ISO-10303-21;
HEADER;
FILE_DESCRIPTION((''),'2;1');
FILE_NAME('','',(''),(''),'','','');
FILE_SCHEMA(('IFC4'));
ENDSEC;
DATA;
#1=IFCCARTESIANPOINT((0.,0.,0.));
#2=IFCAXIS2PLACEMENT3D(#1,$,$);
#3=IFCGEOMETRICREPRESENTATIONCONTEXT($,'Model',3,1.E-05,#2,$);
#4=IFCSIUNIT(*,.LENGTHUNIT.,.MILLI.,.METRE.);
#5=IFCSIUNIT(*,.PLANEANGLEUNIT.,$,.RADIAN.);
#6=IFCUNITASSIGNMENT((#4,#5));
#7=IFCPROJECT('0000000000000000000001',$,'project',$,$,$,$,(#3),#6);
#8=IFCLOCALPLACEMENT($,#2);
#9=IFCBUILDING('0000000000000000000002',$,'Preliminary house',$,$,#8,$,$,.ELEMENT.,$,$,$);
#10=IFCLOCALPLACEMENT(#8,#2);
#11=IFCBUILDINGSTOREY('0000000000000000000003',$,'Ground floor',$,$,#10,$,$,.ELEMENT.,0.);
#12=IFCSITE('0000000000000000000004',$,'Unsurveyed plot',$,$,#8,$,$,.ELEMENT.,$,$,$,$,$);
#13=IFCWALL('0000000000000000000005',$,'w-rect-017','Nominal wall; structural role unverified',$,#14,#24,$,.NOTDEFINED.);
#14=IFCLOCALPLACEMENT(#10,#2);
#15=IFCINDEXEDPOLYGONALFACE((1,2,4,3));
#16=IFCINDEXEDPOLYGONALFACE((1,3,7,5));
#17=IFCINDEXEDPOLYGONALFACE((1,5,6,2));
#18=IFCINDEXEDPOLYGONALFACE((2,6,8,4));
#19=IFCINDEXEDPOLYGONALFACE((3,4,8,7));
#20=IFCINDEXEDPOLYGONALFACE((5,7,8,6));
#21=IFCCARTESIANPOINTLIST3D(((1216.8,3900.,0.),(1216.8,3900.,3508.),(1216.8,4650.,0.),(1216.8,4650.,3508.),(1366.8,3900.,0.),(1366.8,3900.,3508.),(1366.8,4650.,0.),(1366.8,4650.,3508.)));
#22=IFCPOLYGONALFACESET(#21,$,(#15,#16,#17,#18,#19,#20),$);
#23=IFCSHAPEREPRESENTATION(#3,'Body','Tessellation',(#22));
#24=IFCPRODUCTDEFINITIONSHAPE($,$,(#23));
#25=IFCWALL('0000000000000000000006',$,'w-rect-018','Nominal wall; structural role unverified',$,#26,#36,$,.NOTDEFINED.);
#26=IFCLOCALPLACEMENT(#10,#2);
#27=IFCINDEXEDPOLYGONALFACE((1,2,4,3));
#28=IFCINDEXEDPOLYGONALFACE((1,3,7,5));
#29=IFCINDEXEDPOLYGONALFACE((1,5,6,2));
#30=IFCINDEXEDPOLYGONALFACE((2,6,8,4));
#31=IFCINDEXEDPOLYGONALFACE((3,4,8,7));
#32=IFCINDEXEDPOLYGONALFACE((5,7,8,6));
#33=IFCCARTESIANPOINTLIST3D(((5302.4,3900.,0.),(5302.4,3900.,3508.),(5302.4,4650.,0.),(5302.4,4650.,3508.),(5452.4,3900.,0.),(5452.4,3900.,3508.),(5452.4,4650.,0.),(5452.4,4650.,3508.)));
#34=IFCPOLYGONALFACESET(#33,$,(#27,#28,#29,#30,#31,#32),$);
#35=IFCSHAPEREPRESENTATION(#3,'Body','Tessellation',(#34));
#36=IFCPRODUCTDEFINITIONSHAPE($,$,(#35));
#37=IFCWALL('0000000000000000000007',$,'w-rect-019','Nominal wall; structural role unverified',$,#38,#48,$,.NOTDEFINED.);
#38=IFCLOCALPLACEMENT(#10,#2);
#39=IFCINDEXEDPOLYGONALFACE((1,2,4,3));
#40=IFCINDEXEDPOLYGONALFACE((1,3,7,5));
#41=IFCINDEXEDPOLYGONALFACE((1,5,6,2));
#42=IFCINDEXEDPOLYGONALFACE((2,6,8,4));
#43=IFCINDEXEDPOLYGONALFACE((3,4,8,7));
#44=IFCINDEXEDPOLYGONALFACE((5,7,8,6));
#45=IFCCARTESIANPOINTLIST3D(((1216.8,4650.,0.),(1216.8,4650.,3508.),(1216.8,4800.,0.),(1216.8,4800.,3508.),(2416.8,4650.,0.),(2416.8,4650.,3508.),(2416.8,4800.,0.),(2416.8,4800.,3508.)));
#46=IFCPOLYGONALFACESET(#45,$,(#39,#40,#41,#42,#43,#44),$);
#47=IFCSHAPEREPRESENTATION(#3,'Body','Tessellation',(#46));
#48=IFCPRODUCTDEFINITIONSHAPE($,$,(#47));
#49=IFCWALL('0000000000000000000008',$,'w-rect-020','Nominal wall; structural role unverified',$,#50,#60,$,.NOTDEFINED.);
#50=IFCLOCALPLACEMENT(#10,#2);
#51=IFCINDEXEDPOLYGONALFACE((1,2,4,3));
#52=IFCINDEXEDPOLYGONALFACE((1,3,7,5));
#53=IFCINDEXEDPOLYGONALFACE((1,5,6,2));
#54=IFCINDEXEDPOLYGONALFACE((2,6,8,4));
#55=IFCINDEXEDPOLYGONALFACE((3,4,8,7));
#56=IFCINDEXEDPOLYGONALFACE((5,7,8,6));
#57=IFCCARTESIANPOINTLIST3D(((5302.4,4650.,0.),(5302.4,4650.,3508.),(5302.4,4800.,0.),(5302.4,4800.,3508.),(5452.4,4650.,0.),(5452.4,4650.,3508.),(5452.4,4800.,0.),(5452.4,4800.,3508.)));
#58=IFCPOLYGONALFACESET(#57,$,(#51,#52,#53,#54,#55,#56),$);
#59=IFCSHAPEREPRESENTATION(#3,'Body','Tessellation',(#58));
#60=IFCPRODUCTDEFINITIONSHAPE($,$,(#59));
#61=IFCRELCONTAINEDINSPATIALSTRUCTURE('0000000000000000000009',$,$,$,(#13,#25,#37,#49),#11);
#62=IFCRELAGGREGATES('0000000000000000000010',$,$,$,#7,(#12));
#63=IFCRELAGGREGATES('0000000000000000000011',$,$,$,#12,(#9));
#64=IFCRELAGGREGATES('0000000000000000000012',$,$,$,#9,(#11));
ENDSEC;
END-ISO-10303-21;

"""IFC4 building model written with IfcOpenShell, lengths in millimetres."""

from ifc_helpers import new_model, si_unit, origin, place, context, project, spatial, polyline, outline, extrude, element, save


model = new_model("IFC4")

# Units and contexts
model_context = context("Model", 3, precision=1e-05, world=origin())
ifc_project = project(units=[si_unit("LENGTHUNIT", "METRE", prefix="MILLI"), si_unit("PLANEANGLEUNIT", "RADIAN")], contexts=[model_context])

# Site, building, storey
placement_1 = place(None, origin())
site = spatial("IfcSite", under=ifc_project, at=placement_1, Name="Unsurveyed plot", CompositionType="ELEMENT")
building = spatial("IfcBuilding", under=site, at=placement_1, Name="Preliminary house", CompositionType="ELEMENT")
placement_2 = place(placement_1, origin())
storey = spatial("IfcBuildingStorey", under=building, at=placement_2, Name="Ground floor", CompositionType="ELEMENT", Elevation=0.0)

# Walls
element("IfcWall", 1, at=placement_2, inside=storey, Name="w-rect-017", Description="Nominal wall; structural role unverified", PredefinedType="NOTDEFINED", context=model_context, shape_type="SweptSolid", body=[
    extrude(outline(polyline([(1216.8, 3900.0), (1366.8, 3900.0), (1366.8, 4650.0), (1216.8, 4650.0), (1216.8, 3900.0)])), origin(), (0.0, 0.0, 1.0), 3508.0),
])
element("IfcWall", 2, at=placement_2, inside=storey, Name="w-rect-018", Description="Nominal wall; structural role unverified", PredefinedType="NOTDEFINED", context=model_context, shape_type="SweptSolid", body=[
    extrude(outline(polyline([(5302.4, 3900.0), (5452.4, 3900.0), (5452.4, 4650.0), (5302.4, 4650.0), (5302.4, 3900.0)])), origin(), (0.0, 0.0, 1.0), 3508.0),
])
element("IfcWall", 3, at=placement_2, inside=storey, Name="w-rect-019", Description="Nominal wall; structural role unverified", PredefinedType="NOTDEFINED", context=model_context, shape_type="SweptSolid", body=[
    extrude(outline(polyline([(1216.8, 4650.0), (2416.8, 4650.0), (2416.8, 4800.0), (1216.8, 4800.0), (1216.8, 4650.0)])), origin(), (0.0, 0.0, 1.0), 3508.0),
])
element("IfcWall", 4, at=placement_2, inside=storey, Name="w-rect-020", Description="Nominal wall; structural role unverified", PredefinedType="NOTDEFINED", context=model_context, shape_type="SweptSolid", body=[
    extrude(outline(polyline([(5302.4, 4650.0), (5452.4, 4650.0), (5452.4, 4800.0), (5302.4, 4800.0), (5302.4, 4650.0)])), origin(), (0.0, 0.0, 1.0), 3508.0),
])

save(model, "model.ifc")
